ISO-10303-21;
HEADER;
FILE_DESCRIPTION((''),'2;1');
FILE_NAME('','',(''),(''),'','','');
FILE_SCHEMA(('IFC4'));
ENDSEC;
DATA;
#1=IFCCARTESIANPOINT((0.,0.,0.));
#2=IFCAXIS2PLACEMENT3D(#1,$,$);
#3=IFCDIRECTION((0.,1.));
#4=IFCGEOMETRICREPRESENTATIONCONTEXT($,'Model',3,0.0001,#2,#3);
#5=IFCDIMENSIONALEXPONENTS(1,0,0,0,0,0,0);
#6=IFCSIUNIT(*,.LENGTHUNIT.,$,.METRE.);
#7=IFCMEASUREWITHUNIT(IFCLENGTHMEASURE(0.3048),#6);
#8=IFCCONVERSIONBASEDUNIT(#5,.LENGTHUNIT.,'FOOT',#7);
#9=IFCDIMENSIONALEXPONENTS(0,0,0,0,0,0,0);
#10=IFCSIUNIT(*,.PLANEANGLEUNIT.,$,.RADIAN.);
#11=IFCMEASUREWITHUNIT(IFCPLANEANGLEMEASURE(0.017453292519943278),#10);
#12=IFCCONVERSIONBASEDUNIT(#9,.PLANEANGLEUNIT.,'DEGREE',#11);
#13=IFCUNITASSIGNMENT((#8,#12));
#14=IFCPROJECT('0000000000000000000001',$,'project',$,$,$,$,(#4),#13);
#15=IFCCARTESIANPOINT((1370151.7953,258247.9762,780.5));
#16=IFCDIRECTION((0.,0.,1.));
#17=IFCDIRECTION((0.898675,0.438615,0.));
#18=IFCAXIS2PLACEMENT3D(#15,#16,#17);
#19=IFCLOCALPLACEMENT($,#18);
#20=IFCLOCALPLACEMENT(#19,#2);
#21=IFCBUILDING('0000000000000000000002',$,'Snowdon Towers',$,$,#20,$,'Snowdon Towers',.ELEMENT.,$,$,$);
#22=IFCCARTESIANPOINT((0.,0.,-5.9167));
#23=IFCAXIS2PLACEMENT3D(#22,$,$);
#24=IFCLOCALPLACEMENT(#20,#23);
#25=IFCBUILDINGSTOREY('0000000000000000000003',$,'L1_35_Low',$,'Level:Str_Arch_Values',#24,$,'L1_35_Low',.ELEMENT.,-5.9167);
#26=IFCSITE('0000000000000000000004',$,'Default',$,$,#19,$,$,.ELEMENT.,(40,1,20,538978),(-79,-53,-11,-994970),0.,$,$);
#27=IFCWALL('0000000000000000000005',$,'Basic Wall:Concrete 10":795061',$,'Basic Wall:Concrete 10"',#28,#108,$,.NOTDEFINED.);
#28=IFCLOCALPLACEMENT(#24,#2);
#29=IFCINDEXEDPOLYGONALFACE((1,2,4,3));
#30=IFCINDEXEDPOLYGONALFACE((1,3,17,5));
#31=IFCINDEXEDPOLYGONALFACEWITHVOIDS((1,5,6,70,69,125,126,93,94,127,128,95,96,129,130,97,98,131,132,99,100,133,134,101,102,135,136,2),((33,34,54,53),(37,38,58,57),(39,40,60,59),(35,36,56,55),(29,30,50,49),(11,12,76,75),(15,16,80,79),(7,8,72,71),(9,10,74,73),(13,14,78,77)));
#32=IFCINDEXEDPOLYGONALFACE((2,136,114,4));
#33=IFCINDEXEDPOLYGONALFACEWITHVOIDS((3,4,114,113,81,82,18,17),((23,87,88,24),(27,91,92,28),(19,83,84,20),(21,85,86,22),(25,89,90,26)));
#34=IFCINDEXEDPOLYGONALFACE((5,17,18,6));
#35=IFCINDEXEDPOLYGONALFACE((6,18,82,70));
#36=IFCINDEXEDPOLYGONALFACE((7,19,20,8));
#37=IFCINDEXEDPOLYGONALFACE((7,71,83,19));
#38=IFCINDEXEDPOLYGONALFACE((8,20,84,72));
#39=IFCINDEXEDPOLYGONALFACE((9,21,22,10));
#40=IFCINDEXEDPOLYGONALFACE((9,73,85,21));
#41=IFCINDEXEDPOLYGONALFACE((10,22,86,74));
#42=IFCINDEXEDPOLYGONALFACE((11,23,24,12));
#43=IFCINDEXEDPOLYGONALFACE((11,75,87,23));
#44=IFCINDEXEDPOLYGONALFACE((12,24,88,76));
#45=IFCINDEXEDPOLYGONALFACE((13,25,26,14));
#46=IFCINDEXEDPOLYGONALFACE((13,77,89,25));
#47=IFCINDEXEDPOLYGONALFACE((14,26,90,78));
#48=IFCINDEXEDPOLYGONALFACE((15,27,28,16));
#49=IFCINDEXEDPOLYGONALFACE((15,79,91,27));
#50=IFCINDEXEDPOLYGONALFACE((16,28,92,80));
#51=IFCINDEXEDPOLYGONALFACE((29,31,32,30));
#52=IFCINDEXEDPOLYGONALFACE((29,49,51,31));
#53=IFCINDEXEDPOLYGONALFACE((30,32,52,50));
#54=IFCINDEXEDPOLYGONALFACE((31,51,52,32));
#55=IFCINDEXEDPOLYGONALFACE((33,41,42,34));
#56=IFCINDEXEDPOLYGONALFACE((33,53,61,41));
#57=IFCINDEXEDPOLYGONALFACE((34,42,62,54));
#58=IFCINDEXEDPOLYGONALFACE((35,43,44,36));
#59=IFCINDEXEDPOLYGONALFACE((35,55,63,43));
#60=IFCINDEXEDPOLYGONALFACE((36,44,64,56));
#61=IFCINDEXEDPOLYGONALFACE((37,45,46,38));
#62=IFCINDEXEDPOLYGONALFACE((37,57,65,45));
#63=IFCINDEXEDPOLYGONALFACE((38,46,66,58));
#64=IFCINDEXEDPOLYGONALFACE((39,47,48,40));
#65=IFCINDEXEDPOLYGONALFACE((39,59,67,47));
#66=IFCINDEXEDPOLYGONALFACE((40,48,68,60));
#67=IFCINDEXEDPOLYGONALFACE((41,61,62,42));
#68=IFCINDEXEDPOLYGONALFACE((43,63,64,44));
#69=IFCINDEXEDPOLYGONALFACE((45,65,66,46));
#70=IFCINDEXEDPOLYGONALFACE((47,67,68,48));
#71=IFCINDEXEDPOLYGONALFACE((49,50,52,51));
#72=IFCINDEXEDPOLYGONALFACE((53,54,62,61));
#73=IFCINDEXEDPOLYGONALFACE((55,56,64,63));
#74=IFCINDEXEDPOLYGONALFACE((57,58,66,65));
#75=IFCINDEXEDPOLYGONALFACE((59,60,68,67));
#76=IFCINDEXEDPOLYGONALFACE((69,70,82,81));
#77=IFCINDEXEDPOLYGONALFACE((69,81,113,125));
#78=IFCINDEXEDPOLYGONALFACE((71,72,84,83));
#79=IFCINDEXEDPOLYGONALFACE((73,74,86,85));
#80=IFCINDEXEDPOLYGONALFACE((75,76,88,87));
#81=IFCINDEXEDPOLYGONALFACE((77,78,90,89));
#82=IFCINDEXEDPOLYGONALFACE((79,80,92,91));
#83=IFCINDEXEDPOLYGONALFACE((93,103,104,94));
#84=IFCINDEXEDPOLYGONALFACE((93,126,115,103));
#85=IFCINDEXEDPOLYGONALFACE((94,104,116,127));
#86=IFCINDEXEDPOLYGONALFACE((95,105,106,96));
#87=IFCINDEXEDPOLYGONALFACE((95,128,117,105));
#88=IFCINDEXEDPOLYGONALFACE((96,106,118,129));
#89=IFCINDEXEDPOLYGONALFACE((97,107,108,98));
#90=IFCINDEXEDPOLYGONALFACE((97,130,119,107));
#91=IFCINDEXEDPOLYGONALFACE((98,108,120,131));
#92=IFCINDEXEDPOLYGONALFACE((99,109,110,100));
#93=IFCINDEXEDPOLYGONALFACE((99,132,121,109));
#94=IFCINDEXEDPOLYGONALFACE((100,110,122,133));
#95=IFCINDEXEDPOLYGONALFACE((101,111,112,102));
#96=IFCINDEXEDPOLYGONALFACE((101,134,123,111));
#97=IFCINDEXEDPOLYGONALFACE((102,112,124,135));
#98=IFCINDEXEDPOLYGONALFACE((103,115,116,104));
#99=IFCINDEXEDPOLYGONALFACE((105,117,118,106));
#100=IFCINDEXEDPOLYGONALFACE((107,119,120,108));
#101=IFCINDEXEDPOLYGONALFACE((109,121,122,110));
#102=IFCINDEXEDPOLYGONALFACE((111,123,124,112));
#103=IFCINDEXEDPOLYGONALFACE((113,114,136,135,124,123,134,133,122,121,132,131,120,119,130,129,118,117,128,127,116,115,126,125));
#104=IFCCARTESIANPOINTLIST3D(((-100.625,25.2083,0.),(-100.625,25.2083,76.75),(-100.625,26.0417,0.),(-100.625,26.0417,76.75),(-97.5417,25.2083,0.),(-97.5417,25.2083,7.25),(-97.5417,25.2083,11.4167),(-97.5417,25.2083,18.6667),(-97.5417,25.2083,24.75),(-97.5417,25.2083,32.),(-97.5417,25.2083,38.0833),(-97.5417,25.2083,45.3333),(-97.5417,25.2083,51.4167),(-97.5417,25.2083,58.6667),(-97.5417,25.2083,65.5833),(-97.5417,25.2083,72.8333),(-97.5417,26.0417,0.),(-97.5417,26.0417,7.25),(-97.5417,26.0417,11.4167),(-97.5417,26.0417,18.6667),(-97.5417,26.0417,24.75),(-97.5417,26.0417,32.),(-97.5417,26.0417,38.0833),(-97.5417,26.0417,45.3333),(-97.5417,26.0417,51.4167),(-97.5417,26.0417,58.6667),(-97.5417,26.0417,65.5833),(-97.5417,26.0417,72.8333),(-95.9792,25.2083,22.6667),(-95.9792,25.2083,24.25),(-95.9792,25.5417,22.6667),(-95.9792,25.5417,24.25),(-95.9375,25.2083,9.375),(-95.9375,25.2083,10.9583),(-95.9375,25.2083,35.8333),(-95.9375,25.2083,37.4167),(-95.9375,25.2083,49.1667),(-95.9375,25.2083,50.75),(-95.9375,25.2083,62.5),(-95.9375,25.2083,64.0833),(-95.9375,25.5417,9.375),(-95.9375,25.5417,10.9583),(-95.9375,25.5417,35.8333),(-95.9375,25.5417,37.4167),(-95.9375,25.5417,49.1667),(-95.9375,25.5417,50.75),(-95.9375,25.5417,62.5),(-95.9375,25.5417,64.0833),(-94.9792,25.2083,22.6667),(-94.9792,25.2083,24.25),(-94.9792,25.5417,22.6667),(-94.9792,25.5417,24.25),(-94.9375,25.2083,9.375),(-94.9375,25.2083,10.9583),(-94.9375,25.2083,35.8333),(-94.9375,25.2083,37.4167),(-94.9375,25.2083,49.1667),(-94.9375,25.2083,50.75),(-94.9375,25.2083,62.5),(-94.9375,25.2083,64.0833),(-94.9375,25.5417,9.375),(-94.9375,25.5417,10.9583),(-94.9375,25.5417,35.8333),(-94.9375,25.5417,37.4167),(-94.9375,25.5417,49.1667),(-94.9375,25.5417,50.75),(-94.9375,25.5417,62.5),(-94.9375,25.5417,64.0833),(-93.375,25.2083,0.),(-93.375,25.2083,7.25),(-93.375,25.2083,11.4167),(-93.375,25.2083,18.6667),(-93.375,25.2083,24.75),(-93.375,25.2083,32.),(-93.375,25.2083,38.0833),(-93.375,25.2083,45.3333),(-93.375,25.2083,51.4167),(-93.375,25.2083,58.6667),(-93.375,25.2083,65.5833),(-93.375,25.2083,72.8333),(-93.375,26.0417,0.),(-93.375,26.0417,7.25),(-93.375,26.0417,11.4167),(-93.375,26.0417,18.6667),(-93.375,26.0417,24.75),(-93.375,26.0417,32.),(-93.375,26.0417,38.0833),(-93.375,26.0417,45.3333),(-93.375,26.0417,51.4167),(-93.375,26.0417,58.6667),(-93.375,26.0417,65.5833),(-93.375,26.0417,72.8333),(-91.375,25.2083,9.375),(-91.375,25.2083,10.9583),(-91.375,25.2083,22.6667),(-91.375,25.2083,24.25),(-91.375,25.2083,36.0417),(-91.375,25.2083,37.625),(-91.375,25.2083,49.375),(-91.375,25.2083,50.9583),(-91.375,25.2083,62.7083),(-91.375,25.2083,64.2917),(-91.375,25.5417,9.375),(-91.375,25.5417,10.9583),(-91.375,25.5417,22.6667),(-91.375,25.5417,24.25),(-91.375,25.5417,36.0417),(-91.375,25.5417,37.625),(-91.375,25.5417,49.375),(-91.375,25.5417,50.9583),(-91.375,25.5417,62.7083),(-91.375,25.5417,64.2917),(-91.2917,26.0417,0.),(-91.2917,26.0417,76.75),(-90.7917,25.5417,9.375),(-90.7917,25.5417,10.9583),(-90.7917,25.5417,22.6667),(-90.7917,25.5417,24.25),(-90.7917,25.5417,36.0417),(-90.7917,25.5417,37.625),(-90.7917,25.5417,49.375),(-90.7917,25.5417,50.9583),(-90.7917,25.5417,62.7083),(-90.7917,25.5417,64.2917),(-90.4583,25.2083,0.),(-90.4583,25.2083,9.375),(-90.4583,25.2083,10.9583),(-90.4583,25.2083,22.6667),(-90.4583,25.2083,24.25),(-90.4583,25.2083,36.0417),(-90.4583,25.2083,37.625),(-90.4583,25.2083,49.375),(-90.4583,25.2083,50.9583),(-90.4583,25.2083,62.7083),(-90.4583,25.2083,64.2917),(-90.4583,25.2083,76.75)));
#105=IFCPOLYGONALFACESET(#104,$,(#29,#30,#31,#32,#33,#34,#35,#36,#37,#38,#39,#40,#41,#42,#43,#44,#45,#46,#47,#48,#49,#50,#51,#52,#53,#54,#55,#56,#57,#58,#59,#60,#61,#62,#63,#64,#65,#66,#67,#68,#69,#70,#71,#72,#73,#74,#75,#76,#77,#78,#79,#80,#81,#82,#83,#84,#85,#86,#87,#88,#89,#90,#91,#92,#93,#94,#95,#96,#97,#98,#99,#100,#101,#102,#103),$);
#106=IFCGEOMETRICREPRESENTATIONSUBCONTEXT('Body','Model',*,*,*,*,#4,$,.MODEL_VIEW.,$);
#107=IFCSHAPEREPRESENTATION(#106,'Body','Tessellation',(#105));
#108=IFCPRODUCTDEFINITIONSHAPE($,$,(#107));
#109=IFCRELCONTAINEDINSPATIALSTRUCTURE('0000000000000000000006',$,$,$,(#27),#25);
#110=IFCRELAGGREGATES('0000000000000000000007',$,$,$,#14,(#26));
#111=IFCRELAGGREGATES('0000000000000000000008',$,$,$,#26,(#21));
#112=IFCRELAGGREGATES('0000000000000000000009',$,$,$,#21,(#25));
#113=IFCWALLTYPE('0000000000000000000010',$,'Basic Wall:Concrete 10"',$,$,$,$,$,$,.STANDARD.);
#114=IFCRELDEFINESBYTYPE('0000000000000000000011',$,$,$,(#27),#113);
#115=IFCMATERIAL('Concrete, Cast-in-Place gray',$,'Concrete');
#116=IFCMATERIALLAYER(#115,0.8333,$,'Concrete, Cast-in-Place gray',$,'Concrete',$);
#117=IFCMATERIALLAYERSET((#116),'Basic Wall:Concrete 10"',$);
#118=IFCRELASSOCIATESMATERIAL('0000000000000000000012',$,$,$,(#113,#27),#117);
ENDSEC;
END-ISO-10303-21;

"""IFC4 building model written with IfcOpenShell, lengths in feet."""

from ifc_helpers import new_model, entity, si_unit, converted_unit, direction, frame, frame_2d, origin, place, context, subcontext, project, spatial, polyline, rectangle, outline, extrude, material, layer, layer_set, layer_usage, type_object, element, save


model = new_model("IFC4")

# Units and contexts
model_context = context("Model", 3, precision=0.0001, world=origin(), true_north=direction((0.0, 1.0)))
body_context = subcontext(model_context, "Body", "Model", "MODEL_VIEW")
ifc_project = project(units=[converted_unit("LENGTHUNIT", "FOOT", entity("IfcLengthMeasure", 0.3048), si_unit("LENGTHUNIT", "METRE"), dimensions=[1, 0, 0, 0, 0, 0, 0]), converted_unit("PLANEANGLEUNIT", "DEGREE", entity("IfcPlaneAngleMeasure", 0.017453292519943278), si_unit("PLANEANGLEUNIT", "RADIAN"), dimensions=[0, 0, 0, 0, 0, 0, 0])], contexts=[model_context])

# Site, building, storey
site_placement = place(None, frame((1370151.7953, 258247.9762, 780.5), z_axis=(0.0, 0.0, 1.0), x_axis=(0.898675, 0.438615, 0.0)))
site = spatial("IfcSite", under=ifc_project, at=site_placement, Name="Default", CompositionType="ELEMENT", RefLatitude=(40, 1, 20, 538978), RefLongitude=(-79, -53, -11, -994970), RefElevation=0.0)
building_placement = place(site_placement, origin())
building = spatial("IfcBuilding", under=site, at=building_placement, Name="Snowdon Towers", LongName="Snowdon Towers", CompositionType="ELEMENT")
storey_placement = place(building_placement, frame((0.0, 0.0, -5.9167)))
storey = spatial("IfcBuildingStorey", under=building, at=storey_placement, Name="L1_35_Low", ObjectType="Level:Str_Arch_Values", LongName="L1_35_Low", CompositionType="ELEMENT", Elevation=-5.9167)

# Wall, openings
ifc_material = material(Name="Concrete, Cast-in-Place gray", Category="Concrete")
ifc_layer = layer(ifc_material, 0.8333, Name="Concrete, Cast-in-Place gray", Category="Concrete")
ifc_layer_set = layer_set([ifc_layer], Name="Basic Wall:Concrete 10\"")
wall_type = type_object("IfcWallType", Name="Basic Wall:Concrete 10\"", PredefinedType="STANDARD", material=ifc_layer_set)
ifc_layer_usage_1 = layer_usage(ifc_layer_set, "AXIS2", "POSITIVE", -0.4167)
wall_1_placement = place(storey_placement, frame((-90.4583, 25.625, 0.0), z_axis=(0.0, 0.0, 1.0), x_axis=(-1.0, 0.0, 0.0)))
wall_1 = element("IfcWall", 1, at=wall_1_placement, inside=storey, type_object=wall_type, material=ifc_layer_usage_1, Name="Basic Wall:Concrete 10\":795061", ObjectType="Basic Wall:Concrete 10\"", PredefinedType="NOTDEFINED", context=body_context, shape_type="SweptSolid", body=[
    extrude(outline(polyline([(0.8333, -0.4167), (9.1667, -0.4167), (10.1667, -0.4167), (10.1667, 0.4167), (9.1667, 0.4167), (0.0, 0.4167), (0.8333, -0.4167)])), origin(), (0.0, 0.0, 1.0), 76.75),
])
opening_1_placement = place(wall_1_placement, origin())
element("IfcOpeningElement", 2, at=opening_1_placement, cuts=wall_1, PredefinedType="OPENING", context=body_context, shape_type="SweptSolid", body=[
    extrude(rectangle(XDim=7.25, YDim=4.1667, at=frame_2d((0.0, 0.0), x_axis=(0.0, 1.0))), frame((5.0, -5.4167, 3.625), z_axis=(0.0, 1.0, 0.0), x_axis=(-1.0, 0.0, 0.0)), (0.0, 0.0, 1.0), 10.0),
])
opening_2_placement = place(wall_1_placement, origin())
element("IfcOpeningElement", 3, at=opening_2_placement, cuts=wall_1, PredefinedType="RECESS", context=body_context, shape_type="SweptSolid", body=[
    extrude(rectangle(XDim=1.5833, YDim=1.0, at=frame_2d((0.0, 0.0), x_axis=(0.0, 1.0))), frame((0.4167, 0.0833, 63.5), z_axis=(0.0, 1.0, 0.0), x_axis=(1.0, 0.0, 0.0)), (0.0, 0.0, 1.0), 0.3333),
])
opening_3_placement = place(wall_1_placement, origin())
element("IfcOpeningElement", 4, at=opening_3_placement, cuts=wall_1, PredefinedType="RECESS", context=body_context, shape_type="SweptSolid", body=[
    extrude(rectangle(XDim=1.5833, YDim=1.0, at=frame_2d((0.0, 0.0), x_axis=(0.0, 1.0))), frame((0.4167, 0.0833, 10.1667), z_axis=(0.0, 1.0, 0.0), x_axis=(1.0, 0.0, 0.0)), (0.0, 0.0, 1.0), 0.3333),
])
opening_4_placement = place(wall_1_placement, origin())
element("IfcOpeningElement", 5, at=opening_4_placement, cuts=wall_1, PredefinedType="RECESS", context=body_context, shape_type="SweptSolid", body=[
    extrude(rectangle(XDim=1.5833, YDim=1.0, at=frame_2d((0.0, 0.0), x_axis=(0.0, 1.0))), frame((0.4167, 0.0833, 23.4583), z_axis=(0.0, 1.0, 0.0), x_axis=(1.0, 0.0, 0.0)), (0.0, 0.0, 1.0), 0.3333),
])
opening_5_placement = place(wall_1_placement, origin())
element("IfcOpeningElement", 6, at=opening_5_placement, cuts=wall_1, PredefinedType="RECESS", context=body_context, shape_type="SweptSolid", body=[
    extrude(rectangle(XDim=1.5833, YDim=1.0, at=frame_2d((0.0, 0.0), x_axis=(0.0, 1.0))), frame((0.4167, 0.0833, 36.8333), z_axis=(0.0, 1.0, 0.0), x_axis=(1.0, 0.0, 0.0)), (0.0, 0.0, 1.0), 0.3333),
])
opening_6_placement = place(wall_1_placement, origin())
element("IfcOpeningElement", 7, at=opening_6_placement, cuts=wall_1, PredefinedType="RECESS", context=body_context, shape_type="SweptSolid", body=[
    extrude(rectangle(XDim=1.5833, YDim=1.0, at=frame_2d((0.0, 0.0), x_axis=(0.0, 1.0))), frame((0.4167, 0.0833, 50.1667), z_axis=(0.0, 1.0, 0.0), x_axis=(1.0, 0.0, 0.0)), (0.0, 0.0, 1.0), 0.3333),
])
opening_7_placement = place(wall_1_placement, origin())
element("IfcOpeningElement", 8, at=opening_7_placement, cuts=wall_1, PredefinedType="RECESS", context=body_context, shape_type="SweptSolid", body=[
    extrude(rectangle(XDim=1.5833, YDim=1.0, at=frame_2d((0.0, 0.0), x_axis=(0.0, 1.0))), frame((4.9792, 0.0833, 63.2917), z_axis=(0.0, 1.0, 0.0), x_axis=(1.0, 0.0, 0.0)), (0.0, 0.0, 1.0), 0.3333),
])
opening_8_placement = place(wall_1_placement, origin())
element("IfcOpeningElement", 9, at=opening_8_placement, cuts=wall_1, PredefinedType="OPENING", context=body_context, shape_type="SweptSolid", body=[
    extrude(rectangle(XDim=7.25, YDim=4.1667, at=frame_2d((0.0, 0.0), x_axis=(0.0, 1.0))), frame((5.0, -5.4167, 69.2083), z_axis=(0.0, 1.0, 0.0), x_axis=(-1.0, 0.0, 0.0)), (0.0, 0.0, 1.0), 10.0),
])
opening_9_placement = place(wall_1_placement, origin())
element("IfcOpeningElement", 10, at=opening_9_placement, cuts=wall_1, PredefinedType="OPENING", context=body_context, shape_type="SweptSolid", body=[
    extrude(rectangle(XDim=7.25, YDim=4.1667, at=frame_2d((0.0, 0.0), x_axis=(0.0, 1.0))), frame((5.0, -5.4167, 28.375), z_axis=(0.0, 1.0, 0.0), x_axis=(-1.0, 0.0, 0.0)), (0.0, 0.0, 1.0), 10.0),
])
opening_10_placement = place(wall_1_placement, origin())
element("IfcOpeningElement", 11, at=opening_10_placement, cuts=wall_1, PredefinedType="RECESS", context=body_context, shape_type="SweptSolid", body=[
    extrude(rectangle(XDim=1.5833, YDim=1.0, at=frame_2d((0.0, 0.0), x_axis=(0.0, 1.0))), frame((5.0208, 0.0833, 23.4583), z_axis=(0.0, 1.0, 0.0), x_axis=(1.0, 0.0, 0.0)), (0.0, 0.0, 1.0), 0.3333),
])
opening_11_placement = place(wall_1_placement, origin())
element("IfcOpeningElement", 12, at=opening_11_placement, cuts=wall_1, PredefinedType="OPENING", context=body_context, shape_type="SweptSolid", body=[
    extrude(rectangle(XDim=7.25, YDim=4.1667, at=frame_2d((0.0, 0.0), x_axis=(0.0, 1.0))), frame((5.0, -5.4167, 15.0417), z_axis=(0.0, 1.0, 0.0), x_axis=(-1.0, 0.0, 0.0)), (0.0, 0.0, 1.0), 10.0),
])
opening_12_placement = place(wall_1_placement, origin())
element("IfcOpeningElement", 13, at=opening_12_placement, cuts=wall_1, PredefinedType="OPENING", context=body_context, shape_type="SweptSolid", body=[
    extrude(rectangle(XDim=7.25, YDim=4.1667, at=frame_2d((0.0, 0.0), x_axis=(0.0, 1.0))), frame((5.0, -5.4167, 41.7083), z_axis=(0.0, 1.0, 0.0), x_axis=(-1.0, 0.0, 0.0)), (0.0, 0.0, 1.0), 10.0),
])
opening_13_placement = place(wall_1_placement, origin())
element("IfcOpeningElement", 14, at=opening_13_placement, cuts=wall_1, PredefinedType="OPENING", context=body_context, shape_type="SweptSolid", body=[
    extrude(rectangle(XDim=7.25, YDim=4.1667, at=frame_2d((0.0, 0.0), x_axis=(0.0, 1.0))), frame((5.0, -5.4167, 55.0417), z_axis=(0.0, 1.0, 0.0), x_axis=(-1.0, 0.0, 0.0)), (0.0, 0.0, 1.0), 10.0),
])
opening_14_placement = place(wall_1_placement, origin())
element("IfcOpeningElement", 15, at=opening_14_placement, cuts=wall_1, PredefinedType="RECESS", context=body_context, shape_type="SweptSolid", body=[
    extrude(rectangle(XDim=1.5833, YDim=1.0, at=frame_2d((0.0, 0.0), x_axis=(0.0, 1.0))), frame((4.9792, 0.0833, 10.1667), z_axis=(0.0, 1.0, 0.0), x_axis=(1.0, 0.0, 0.0)), (0.0, 0.0, 1.0), 0.3333),
])
opening_15_placement = place(wall_1_placement, origin())
element("IfcOpeningElement", 16, at=opening_15_placement, cuts=wall_1, PredefinedType="RECESS", context=body_context, shape_type="SweptSolid", body=[
    extrude(rectangle(XDim=1.5833, YDim=1.0, at=frame_2d((0.0, 0.0), x_axis=(0.0, 1.0))), frame((4.9792, 0.0833, 36.625), z_axis=(0.0, 1.0, 0.0), x_axis=(1.0, 0.0, 0.0)), (0.0, 0.0, 1.0), 0.3333),
])
opening_16_placement = place(wall_1_placement, origin())
element("IfcOpeningElement", 17, at=opening_16_placement, cuts=wall_1, PredefinedType="RECESS", context=body_context, shape_type="SweptSolid", body=[
    extrude(rectangle(XDim=1.5833, YDim=1.0, at=frame_2d((0.0, 0.0), x_axis=(0.0, 1.0))), frame((4.9792, 0.0833, 49.9583), z_axis=(0.0, 1.0, 0.0), x_axis=(1.0, 0.0, 0.0)), (0.0, 0.0, 1.0), 0.3333),
])

save(model, "model.ifc")
